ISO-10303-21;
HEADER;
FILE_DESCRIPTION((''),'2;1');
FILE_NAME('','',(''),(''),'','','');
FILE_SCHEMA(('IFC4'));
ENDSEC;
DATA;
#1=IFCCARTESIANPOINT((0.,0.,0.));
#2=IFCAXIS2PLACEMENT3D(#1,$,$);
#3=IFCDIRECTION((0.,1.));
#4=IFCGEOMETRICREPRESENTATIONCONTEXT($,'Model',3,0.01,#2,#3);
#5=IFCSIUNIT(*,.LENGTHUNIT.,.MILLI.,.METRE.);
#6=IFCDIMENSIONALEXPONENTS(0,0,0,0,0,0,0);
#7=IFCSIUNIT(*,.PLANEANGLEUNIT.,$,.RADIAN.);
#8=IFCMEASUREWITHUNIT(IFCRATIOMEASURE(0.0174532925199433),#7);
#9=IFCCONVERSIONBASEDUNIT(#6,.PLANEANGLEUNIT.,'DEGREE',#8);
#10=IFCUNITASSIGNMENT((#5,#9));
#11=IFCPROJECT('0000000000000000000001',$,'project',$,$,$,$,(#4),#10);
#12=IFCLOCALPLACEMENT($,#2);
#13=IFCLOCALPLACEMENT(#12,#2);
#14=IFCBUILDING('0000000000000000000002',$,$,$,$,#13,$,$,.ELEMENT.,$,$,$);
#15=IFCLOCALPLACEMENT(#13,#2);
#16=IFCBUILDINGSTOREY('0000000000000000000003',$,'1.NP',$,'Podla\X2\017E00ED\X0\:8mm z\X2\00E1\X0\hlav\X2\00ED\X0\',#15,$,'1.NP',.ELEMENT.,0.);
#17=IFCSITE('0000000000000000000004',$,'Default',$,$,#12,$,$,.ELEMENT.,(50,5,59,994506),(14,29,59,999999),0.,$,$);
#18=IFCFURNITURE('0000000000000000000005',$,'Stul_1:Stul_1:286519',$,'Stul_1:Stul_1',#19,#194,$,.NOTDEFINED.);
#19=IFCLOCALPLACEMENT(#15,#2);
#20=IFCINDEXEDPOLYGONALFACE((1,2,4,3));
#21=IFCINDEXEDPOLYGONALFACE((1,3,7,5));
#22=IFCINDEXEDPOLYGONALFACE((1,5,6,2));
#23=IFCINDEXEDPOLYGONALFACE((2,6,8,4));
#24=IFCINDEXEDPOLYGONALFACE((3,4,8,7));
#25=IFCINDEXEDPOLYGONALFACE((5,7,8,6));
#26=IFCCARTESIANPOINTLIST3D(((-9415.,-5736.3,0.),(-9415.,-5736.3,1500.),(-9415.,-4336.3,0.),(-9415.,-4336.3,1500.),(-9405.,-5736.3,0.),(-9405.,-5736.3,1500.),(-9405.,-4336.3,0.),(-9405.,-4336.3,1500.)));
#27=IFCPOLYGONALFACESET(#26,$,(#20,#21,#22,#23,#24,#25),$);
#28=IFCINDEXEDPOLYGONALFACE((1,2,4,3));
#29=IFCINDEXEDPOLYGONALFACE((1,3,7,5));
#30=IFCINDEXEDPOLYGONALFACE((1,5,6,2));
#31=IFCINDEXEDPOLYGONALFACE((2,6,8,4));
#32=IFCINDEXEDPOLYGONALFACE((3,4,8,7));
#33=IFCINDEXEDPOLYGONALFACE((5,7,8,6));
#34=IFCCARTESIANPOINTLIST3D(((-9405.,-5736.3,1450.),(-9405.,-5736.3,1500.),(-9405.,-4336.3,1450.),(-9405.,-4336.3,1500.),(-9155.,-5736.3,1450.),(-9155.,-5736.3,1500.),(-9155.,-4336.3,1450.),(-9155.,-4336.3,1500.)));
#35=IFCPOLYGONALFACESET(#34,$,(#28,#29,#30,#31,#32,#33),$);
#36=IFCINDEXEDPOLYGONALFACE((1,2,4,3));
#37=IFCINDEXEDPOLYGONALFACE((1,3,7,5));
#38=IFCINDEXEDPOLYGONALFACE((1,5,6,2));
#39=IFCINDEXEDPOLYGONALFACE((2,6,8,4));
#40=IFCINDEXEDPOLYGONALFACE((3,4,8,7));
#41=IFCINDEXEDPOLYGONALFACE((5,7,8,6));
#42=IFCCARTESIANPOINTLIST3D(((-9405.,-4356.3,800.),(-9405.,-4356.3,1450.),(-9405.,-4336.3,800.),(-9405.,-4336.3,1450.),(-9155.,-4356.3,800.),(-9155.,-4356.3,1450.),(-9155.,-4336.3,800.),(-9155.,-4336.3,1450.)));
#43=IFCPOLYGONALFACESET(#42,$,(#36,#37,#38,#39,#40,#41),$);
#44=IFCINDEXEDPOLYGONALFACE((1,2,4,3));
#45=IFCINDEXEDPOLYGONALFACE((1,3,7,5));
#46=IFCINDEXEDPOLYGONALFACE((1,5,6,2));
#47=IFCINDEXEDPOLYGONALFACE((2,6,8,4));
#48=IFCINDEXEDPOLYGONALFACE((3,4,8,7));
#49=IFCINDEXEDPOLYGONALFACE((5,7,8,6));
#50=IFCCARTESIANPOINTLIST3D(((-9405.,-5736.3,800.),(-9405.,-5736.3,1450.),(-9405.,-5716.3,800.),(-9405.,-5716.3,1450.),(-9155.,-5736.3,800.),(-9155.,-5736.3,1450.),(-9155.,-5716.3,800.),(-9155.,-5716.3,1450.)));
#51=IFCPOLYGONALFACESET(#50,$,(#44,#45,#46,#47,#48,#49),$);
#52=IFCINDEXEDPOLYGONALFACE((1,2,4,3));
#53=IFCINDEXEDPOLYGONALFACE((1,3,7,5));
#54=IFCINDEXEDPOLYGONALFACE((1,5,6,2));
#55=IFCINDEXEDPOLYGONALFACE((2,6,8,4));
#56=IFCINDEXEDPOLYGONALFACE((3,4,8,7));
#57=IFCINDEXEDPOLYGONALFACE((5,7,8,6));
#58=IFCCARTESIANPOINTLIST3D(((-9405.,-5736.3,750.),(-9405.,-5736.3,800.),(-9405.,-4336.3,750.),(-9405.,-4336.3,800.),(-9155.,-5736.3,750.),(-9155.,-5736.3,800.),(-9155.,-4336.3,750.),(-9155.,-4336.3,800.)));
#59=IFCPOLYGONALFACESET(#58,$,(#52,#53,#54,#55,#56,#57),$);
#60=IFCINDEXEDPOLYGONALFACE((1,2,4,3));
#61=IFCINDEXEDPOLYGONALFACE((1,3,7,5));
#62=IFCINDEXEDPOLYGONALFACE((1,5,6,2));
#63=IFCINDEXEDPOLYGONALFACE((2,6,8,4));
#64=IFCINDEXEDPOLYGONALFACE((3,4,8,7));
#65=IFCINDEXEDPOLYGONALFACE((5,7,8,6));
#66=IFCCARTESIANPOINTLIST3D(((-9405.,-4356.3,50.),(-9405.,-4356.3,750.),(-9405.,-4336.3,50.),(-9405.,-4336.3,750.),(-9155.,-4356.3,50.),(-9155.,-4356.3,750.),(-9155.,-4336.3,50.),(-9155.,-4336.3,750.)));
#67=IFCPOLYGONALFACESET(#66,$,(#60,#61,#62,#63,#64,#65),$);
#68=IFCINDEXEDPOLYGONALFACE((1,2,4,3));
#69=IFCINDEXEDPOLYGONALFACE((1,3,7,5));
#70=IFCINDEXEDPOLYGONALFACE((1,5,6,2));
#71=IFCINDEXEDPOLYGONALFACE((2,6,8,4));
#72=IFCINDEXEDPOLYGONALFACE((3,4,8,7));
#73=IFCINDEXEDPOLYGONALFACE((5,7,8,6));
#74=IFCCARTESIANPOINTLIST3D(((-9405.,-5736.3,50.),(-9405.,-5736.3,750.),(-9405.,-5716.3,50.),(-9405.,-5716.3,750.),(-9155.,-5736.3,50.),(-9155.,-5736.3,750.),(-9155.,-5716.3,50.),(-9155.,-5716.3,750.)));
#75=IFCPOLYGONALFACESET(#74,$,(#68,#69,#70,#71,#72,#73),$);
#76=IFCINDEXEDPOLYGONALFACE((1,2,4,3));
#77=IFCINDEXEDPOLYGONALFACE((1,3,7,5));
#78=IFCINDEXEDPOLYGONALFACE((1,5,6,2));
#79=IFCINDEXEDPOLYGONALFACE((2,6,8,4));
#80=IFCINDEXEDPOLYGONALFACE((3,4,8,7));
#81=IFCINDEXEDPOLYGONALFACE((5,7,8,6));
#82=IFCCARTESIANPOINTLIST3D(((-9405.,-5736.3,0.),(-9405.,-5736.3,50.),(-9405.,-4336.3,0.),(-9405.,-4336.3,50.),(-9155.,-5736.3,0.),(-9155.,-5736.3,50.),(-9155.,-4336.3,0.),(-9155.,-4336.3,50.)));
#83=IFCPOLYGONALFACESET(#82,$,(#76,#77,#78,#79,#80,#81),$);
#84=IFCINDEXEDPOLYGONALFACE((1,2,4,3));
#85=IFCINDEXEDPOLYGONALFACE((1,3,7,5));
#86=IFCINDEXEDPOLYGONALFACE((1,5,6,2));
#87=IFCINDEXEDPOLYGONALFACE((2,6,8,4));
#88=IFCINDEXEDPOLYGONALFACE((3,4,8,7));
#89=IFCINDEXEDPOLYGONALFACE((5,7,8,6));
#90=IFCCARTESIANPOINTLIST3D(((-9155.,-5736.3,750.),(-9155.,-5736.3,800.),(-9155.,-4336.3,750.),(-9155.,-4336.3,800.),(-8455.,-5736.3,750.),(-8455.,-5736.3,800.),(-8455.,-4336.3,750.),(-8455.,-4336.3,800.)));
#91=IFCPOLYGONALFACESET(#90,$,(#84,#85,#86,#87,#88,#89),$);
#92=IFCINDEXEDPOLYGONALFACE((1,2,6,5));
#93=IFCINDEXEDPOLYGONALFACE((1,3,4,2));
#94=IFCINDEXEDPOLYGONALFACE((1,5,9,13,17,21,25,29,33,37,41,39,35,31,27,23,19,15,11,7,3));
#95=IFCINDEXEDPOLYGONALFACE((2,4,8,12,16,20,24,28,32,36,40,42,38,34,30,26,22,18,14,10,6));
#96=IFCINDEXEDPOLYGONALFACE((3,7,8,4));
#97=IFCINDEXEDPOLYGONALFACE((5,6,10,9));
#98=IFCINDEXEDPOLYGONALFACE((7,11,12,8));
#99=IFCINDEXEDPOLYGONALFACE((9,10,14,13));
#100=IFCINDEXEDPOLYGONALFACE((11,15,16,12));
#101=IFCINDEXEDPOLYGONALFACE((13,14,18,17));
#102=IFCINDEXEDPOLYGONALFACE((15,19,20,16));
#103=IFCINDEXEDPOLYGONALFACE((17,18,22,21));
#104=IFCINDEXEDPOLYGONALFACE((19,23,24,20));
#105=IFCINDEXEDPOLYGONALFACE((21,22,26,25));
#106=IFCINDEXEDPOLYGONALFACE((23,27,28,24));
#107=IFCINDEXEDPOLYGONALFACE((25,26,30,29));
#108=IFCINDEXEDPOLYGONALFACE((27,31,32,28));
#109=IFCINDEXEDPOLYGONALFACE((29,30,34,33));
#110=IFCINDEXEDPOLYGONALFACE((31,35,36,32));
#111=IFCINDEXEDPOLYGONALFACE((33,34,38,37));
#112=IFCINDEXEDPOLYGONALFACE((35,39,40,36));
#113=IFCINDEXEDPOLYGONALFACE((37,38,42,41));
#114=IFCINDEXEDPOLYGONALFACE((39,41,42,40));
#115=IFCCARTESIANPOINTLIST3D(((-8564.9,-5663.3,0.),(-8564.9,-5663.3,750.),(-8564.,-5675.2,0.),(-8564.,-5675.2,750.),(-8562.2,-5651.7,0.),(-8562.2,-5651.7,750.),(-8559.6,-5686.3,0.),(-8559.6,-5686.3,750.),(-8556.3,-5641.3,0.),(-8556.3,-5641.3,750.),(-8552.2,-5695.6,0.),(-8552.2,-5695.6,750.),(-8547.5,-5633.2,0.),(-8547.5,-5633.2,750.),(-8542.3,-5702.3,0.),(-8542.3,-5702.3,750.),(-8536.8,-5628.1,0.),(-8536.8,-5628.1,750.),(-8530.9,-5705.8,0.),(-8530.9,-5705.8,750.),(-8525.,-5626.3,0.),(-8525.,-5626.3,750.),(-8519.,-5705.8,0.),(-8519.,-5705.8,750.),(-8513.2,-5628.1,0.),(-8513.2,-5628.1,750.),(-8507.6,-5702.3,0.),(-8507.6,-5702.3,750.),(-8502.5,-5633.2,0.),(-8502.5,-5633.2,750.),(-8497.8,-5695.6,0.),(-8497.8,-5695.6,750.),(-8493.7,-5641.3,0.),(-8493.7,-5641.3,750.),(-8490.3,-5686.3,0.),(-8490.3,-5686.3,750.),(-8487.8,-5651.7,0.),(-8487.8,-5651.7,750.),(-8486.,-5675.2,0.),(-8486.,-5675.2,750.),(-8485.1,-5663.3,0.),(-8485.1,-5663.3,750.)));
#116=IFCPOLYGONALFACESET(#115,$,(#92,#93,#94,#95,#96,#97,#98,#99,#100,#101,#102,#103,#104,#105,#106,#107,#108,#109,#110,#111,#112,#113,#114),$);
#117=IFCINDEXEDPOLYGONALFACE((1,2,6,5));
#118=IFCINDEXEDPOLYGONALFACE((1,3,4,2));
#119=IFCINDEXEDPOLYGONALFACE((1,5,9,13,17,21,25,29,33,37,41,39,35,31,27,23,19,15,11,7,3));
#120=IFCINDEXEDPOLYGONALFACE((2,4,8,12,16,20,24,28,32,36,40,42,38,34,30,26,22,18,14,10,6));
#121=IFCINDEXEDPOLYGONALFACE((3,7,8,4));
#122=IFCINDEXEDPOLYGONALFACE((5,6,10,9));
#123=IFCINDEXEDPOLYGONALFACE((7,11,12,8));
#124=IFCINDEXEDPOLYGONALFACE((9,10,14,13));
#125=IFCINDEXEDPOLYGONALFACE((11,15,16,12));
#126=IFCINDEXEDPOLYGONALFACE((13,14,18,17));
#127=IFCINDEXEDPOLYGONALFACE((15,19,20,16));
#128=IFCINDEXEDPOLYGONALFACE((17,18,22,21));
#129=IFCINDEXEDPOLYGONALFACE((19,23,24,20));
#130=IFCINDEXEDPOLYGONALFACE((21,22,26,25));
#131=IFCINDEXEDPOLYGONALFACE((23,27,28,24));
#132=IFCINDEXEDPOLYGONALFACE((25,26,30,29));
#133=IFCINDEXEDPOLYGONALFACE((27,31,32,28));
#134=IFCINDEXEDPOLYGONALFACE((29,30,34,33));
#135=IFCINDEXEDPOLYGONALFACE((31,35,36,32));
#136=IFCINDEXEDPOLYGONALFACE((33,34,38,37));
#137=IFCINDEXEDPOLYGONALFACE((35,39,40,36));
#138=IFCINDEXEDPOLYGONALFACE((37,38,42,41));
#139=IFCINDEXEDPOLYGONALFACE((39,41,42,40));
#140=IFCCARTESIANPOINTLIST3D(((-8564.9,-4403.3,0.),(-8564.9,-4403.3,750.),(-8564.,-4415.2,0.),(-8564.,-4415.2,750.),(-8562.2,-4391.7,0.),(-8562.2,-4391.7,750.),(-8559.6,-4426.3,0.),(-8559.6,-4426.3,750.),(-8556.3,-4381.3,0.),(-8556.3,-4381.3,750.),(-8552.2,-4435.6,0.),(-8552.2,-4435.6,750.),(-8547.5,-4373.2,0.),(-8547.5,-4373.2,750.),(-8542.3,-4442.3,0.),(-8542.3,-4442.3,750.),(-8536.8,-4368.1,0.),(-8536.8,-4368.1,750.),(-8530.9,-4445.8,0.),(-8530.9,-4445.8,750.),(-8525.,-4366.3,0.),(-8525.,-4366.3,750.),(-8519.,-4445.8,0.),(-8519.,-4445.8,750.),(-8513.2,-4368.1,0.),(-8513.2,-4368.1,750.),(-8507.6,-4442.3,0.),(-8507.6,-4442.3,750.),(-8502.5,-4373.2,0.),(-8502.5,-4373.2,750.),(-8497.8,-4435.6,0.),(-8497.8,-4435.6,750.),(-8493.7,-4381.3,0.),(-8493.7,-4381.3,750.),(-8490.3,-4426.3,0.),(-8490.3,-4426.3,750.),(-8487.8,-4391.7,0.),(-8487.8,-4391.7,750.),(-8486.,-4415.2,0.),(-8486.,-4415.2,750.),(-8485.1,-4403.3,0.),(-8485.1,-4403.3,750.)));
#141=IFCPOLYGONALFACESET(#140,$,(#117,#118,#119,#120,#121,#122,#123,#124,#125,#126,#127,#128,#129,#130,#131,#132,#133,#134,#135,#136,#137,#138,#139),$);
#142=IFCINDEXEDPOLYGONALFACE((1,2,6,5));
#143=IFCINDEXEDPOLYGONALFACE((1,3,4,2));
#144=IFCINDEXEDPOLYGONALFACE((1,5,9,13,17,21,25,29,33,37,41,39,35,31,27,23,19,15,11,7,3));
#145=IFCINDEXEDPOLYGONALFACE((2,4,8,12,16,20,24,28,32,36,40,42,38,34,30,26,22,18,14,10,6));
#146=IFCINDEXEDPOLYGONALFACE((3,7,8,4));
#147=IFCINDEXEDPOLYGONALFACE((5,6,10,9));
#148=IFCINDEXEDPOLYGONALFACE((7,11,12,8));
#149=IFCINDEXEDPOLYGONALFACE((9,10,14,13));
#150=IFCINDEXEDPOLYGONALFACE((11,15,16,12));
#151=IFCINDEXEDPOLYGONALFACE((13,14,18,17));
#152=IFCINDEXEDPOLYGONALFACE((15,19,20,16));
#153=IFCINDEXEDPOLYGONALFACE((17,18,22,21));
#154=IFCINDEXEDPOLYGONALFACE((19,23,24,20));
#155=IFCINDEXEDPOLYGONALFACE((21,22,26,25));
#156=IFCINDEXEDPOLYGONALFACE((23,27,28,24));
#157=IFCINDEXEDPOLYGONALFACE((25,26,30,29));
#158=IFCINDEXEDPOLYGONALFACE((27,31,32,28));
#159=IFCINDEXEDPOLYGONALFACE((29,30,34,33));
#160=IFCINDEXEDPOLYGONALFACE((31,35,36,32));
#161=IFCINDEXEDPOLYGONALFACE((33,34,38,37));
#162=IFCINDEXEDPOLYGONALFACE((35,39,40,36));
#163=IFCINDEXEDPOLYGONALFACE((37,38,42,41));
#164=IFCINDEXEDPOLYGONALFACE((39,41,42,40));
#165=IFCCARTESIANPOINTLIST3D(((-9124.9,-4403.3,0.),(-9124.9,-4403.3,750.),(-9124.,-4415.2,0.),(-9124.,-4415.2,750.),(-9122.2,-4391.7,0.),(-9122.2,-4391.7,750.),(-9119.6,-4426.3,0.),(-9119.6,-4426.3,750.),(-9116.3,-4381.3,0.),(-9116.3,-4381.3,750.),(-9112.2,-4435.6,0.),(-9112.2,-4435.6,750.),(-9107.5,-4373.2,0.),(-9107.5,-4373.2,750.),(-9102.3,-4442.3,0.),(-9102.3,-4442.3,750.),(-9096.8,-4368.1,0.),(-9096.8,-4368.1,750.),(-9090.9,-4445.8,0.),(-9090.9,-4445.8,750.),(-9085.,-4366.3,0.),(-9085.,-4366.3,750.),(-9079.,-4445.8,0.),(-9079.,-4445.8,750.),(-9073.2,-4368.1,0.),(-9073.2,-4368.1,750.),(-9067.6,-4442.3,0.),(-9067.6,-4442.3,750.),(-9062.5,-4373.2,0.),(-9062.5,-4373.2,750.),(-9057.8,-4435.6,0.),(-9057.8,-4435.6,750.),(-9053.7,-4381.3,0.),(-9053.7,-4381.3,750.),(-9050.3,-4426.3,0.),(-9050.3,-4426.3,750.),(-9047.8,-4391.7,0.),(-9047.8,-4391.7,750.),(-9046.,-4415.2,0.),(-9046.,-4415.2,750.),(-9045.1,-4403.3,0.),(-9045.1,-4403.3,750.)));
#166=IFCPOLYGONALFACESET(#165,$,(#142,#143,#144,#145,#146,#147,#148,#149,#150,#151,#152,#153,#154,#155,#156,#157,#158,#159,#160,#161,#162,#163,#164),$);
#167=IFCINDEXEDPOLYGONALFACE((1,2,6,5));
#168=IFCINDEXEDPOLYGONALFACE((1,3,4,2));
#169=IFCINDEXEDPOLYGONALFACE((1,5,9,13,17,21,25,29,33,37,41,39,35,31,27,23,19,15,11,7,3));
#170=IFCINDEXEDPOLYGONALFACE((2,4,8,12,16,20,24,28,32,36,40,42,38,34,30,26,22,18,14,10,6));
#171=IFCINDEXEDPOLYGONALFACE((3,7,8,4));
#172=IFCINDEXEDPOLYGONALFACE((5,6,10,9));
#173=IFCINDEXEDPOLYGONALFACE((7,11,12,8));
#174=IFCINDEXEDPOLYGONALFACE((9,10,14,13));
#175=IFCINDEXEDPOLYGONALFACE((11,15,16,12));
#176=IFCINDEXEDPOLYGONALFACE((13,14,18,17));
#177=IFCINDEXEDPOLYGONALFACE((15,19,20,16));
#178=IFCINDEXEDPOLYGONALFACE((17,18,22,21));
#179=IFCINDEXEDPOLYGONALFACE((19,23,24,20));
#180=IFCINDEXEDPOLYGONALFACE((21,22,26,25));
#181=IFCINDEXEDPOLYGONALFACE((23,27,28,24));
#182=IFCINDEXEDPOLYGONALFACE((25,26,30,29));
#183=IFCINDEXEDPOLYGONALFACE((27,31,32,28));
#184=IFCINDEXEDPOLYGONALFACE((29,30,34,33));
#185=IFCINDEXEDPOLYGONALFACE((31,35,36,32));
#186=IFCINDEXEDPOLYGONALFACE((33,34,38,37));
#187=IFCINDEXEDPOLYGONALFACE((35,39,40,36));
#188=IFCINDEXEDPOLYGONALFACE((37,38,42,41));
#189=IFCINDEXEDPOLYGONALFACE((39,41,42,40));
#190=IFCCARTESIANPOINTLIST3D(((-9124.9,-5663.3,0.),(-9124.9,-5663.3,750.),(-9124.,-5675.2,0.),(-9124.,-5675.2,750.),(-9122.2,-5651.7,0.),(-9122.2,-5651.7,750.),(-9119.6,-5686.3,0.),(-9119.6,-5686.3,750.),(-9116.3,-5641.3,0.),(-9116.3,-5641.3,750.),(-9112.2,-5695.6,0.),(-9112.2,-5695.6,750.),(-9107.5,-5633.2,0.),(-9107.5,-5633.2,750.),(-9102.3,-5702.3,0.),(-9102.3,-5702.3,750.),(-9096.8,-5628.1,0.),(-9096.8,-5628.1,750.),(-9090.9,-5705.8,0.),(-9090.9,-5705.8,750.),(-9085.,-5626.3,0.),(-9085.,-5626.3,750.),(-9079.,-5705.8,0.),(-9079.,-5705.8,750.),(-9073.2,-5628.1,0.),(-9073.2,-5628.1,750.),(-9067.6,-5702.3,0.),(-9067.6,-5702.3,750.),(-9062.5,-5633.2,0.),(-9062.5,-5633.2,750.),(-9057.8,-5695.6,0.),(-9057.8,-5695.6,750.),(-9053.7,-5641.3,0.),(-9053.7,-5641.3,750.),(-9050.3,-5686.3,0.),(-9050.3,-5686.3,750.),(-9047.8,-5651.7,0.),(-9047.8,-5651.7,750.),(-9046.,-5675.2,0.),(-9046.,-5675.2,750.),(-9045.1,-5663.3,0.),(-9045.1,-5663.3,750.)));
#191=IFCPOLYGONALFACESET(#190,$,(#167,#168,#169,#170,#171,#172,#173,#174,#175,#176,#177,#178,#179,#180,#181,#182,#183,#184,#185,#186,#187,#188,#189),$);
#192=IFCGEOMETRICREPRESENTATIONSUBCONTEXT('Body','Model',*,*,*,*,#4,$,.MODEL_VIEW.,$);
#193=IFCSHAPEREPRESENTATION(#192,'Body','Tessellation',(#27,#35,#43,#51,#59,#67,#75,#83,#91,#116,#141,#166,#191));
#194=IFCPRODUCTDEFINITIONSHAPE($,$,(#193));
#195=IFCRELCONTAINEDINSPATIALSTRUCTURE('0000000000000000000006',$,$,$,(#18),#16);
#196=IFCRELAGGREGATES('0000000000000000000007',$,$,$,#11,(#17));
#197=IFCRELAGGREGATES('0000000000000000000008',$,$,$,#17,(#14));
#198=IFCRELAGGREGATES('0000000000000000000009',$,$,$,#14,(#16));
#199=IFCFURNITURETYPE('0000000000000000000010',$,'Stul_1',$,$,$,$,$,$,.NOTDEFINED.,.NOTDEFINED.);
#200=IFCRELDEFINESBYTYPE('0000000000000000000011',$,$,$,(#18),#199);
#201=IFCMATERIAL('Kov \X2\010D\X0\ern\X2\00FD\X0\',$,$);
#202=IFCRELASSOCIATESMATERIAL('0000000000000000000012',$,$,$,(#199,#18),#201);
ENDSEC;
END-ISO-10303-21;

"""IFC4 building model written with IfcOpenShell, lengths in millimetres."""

from ifc_helpers import new_model, entity, si_unit, converted_unit, direction, frame, frame_2d, origin, origin_2d_with_axis, place, context, subcontext, project, spatial, rectangle, circle, extrude, source, transform, mapped, material, type_object, type_shapes, element, save


model = new_model("IFC4")

# Units and contexts
model_context = context("Model", 3, precision=0.01, world=origin(), true_north=direction((0.0, 1.0)))
body_context = subcontext(model_context, "Body", "Model", "MODEL_VIEW")
ifc_project = project(units=[si_unit("LENGTHUNIT", "METRE", prefix="MILLI"), converted_unit("PLANEANGLEUNIT", "DEGREE", entity("IfcRatioMeasure", 0.0174532925199433), si_unit("PLANEANGLEUNIT", "RADIAN"), dimensions=[0, 0, 0, 0, 0, 0, 0])], contexts=[model_context])

# Site, building, storey
site_placement = place(None, origin())
site = spatial("IfcSite", under=ifc_project, at=site_placement, Name="Default", CompositionType="ELEMENT", RefLatitude=(50, 5, 59, 994506), RefLongitude=(14, 29, 59, 999999), RefElevation=0.0)
building_placement = place(site_placement, origin())
building = spatial("IfcBuilding", under=site, at=building_placement, CompositionType="ELEMENT")
storey_placement = place(building_placement, origin())
storey = spatial("IfcBuildingStorey", under=building, at=storey_placement, Name="1.NP", ObjectType="Podlaží:8mm záhlaví", LongName="1.NP", CompositionType="ELEMENT", Elevation=0.0)

# Furniture
ifc_material_1 = material(Name="Kov černý")
furniture_type = type_object("IfcFurnitureType", Name="Stul_1", AssemblyPlace="NOTDEFINED", PredefinedType="NOTDEFINED", material=ifc_material_1)
shared_shape_1 = source(origin(), body_context, "Body", "SweptSolid", [
    extrude(rectangle(XDim=1400.0, YDim=10.0, at=origin_2d_with_axis()), frame((0.0, 605.0, 0.0), z_axis=(0.0, 0.0, 1.0), x_axis=(-1.0, 0.0, 0.0)), (0.0, 0.0, 1.0), 1500.0),
    extrude(rectangle(XDim=1400.0, YDim=250.0, at=frame_2d((0.0, 0.0), x_axis=(1.0, 0.0))), frame((0.0, 475.0, 1450.0), z_axis=(0.0, 0.0, 1.0), x_axis=(-1.0, 0.0, 0.0)), (0.0, 0.0, 1.0), 50.0),
    extrude(rectangle(XDim=20.0, YDim=250.0, at=origin_2d_with_axis()), frame((690.0, 475.0, 800.0), z_axis=(0.0, 0.0, 1.0), x_axis=(-1.0, 0.0, 0.0)), (0.0, 0.0, 1.0), 650.0),
    extrude(rectangle(XDim=20.0, YDim=250.0, at=frame_2d((0.0, 0.0), x_axis=(1.0, 0.0))), frame((-690.0, 475.0, 800.0), z_axis=(0.0, 0.0, 1.0), x_axis=(-1.0, 0.0, 0.0)), (0.0, 0.0, 1.0), 650.0),
    extrude(rectangle(XDim=1400.0, YDim=250.0, at=origin_2d_with_axis()), frame((0.0, 475.0, 750.0), z_axis=(0.0, 0.0, 1.0), x_axis=(-1.0, 0.0, 0.0)), (0.0, 0.0, 1.0), 50.0),
    extrude(rectangle(XDim=20.0, YDim=250.0, at=origin_2d_with_axis()), frame((690.0, 475.0, 50.0), z_axis=(0.0, 0.0, 1.0), x_axis=(-1.0, 0.0, 0.0)), (0.0, 0.0, 1.0), 700.0),
    extrude(rectangle(XDim=20.0, YDim=250.0, at=frame_2d((0.0, 0.0), x_axis=(1.0, 0.0))), frame((-690.0, 475.0, 50.0), z_axis=(0.0, 0.0, 1.0), x_axis=(-1.0, 0.0, 0.0)), (0.0, 0.0, 1.0), 700.0),
    extrude(rectangle(XDim=1400.0, YDim=250.0, at=origin_2d_with_axis()), frame((0.0, 475.0, 0.0), z_axis=(0.0, 0.0, 1.0), x_axis=(-1.0, 0.0, 0.0)), (0.0, 0.0, 1.0), 50.0),
    extrude(rectangle(XDim=1400.0, YDim=700.0, at=origin_2d_with_axis()), frame((0.0, 0.0, 750.0), z_axis=(0.0, 0.0, 1.0), x_axis=(-1.0, 0.0, 0.0)), (0.0, 0.0, 1.0), 50.0),
    extrude(circle(Radius=40.0, at=frame_2d((0.0, 0.0), x_axis=(1.0, 0.0))), frame((-630.0, -280.0, 0.0)), (0.0, 0.0, 1.0), 750.0),
    extrude(circle(Radius=40.0, at=frame_2d((0.0, 0.0), x_axis=(1.0, 0.0))), frame((630.0, -280.0, 0.0)), (0.0, 0.0, 1.0), 750.0),
    extrude(circle(Radius=40.0, at=frame_2d((0.0, 0.0), x_axis=(1.0, 0.0))), frame((630.0, 280.0, 0.0)), (0.0, 0.0, 1.0), 750.0),
    extrude(circle(Radius=40.0, at=frame_2d((0.0, 0.0), x_axis=(1.0, 0.0))), frame((-630.0, 280.0, 0.0)), (0.0, 0.0, 1.0), 750.0),
])
type_shapes(furniture_type, [shared_shape_1])
for number, where, z_axis, x_axis, name in (
    (1, (-8805.0, -5036.3, 0.0), (0.0, 0.0, 1.0), (0.0, 1.0, 0.0), "Stul_1:Stul_1:286519"),
):
    element("IfcFurniture", number, at=place(storey_placement, frame(where, z_axis=z_axis, x_axis=x_axis)), inside=storey, type_object=furniture_type, material=ifc_material_1, Name=name, ObjectType="Stul_1:Stul_1", PredefinedType="NOTDEFINED", context=body_context, shape_type="MappedRepresentation", body=[
        mapped(shared_shape_1, transform((0.0, 0.0, 0.0), scale=1.0)),
    ])

save(model, "model.ifc")
